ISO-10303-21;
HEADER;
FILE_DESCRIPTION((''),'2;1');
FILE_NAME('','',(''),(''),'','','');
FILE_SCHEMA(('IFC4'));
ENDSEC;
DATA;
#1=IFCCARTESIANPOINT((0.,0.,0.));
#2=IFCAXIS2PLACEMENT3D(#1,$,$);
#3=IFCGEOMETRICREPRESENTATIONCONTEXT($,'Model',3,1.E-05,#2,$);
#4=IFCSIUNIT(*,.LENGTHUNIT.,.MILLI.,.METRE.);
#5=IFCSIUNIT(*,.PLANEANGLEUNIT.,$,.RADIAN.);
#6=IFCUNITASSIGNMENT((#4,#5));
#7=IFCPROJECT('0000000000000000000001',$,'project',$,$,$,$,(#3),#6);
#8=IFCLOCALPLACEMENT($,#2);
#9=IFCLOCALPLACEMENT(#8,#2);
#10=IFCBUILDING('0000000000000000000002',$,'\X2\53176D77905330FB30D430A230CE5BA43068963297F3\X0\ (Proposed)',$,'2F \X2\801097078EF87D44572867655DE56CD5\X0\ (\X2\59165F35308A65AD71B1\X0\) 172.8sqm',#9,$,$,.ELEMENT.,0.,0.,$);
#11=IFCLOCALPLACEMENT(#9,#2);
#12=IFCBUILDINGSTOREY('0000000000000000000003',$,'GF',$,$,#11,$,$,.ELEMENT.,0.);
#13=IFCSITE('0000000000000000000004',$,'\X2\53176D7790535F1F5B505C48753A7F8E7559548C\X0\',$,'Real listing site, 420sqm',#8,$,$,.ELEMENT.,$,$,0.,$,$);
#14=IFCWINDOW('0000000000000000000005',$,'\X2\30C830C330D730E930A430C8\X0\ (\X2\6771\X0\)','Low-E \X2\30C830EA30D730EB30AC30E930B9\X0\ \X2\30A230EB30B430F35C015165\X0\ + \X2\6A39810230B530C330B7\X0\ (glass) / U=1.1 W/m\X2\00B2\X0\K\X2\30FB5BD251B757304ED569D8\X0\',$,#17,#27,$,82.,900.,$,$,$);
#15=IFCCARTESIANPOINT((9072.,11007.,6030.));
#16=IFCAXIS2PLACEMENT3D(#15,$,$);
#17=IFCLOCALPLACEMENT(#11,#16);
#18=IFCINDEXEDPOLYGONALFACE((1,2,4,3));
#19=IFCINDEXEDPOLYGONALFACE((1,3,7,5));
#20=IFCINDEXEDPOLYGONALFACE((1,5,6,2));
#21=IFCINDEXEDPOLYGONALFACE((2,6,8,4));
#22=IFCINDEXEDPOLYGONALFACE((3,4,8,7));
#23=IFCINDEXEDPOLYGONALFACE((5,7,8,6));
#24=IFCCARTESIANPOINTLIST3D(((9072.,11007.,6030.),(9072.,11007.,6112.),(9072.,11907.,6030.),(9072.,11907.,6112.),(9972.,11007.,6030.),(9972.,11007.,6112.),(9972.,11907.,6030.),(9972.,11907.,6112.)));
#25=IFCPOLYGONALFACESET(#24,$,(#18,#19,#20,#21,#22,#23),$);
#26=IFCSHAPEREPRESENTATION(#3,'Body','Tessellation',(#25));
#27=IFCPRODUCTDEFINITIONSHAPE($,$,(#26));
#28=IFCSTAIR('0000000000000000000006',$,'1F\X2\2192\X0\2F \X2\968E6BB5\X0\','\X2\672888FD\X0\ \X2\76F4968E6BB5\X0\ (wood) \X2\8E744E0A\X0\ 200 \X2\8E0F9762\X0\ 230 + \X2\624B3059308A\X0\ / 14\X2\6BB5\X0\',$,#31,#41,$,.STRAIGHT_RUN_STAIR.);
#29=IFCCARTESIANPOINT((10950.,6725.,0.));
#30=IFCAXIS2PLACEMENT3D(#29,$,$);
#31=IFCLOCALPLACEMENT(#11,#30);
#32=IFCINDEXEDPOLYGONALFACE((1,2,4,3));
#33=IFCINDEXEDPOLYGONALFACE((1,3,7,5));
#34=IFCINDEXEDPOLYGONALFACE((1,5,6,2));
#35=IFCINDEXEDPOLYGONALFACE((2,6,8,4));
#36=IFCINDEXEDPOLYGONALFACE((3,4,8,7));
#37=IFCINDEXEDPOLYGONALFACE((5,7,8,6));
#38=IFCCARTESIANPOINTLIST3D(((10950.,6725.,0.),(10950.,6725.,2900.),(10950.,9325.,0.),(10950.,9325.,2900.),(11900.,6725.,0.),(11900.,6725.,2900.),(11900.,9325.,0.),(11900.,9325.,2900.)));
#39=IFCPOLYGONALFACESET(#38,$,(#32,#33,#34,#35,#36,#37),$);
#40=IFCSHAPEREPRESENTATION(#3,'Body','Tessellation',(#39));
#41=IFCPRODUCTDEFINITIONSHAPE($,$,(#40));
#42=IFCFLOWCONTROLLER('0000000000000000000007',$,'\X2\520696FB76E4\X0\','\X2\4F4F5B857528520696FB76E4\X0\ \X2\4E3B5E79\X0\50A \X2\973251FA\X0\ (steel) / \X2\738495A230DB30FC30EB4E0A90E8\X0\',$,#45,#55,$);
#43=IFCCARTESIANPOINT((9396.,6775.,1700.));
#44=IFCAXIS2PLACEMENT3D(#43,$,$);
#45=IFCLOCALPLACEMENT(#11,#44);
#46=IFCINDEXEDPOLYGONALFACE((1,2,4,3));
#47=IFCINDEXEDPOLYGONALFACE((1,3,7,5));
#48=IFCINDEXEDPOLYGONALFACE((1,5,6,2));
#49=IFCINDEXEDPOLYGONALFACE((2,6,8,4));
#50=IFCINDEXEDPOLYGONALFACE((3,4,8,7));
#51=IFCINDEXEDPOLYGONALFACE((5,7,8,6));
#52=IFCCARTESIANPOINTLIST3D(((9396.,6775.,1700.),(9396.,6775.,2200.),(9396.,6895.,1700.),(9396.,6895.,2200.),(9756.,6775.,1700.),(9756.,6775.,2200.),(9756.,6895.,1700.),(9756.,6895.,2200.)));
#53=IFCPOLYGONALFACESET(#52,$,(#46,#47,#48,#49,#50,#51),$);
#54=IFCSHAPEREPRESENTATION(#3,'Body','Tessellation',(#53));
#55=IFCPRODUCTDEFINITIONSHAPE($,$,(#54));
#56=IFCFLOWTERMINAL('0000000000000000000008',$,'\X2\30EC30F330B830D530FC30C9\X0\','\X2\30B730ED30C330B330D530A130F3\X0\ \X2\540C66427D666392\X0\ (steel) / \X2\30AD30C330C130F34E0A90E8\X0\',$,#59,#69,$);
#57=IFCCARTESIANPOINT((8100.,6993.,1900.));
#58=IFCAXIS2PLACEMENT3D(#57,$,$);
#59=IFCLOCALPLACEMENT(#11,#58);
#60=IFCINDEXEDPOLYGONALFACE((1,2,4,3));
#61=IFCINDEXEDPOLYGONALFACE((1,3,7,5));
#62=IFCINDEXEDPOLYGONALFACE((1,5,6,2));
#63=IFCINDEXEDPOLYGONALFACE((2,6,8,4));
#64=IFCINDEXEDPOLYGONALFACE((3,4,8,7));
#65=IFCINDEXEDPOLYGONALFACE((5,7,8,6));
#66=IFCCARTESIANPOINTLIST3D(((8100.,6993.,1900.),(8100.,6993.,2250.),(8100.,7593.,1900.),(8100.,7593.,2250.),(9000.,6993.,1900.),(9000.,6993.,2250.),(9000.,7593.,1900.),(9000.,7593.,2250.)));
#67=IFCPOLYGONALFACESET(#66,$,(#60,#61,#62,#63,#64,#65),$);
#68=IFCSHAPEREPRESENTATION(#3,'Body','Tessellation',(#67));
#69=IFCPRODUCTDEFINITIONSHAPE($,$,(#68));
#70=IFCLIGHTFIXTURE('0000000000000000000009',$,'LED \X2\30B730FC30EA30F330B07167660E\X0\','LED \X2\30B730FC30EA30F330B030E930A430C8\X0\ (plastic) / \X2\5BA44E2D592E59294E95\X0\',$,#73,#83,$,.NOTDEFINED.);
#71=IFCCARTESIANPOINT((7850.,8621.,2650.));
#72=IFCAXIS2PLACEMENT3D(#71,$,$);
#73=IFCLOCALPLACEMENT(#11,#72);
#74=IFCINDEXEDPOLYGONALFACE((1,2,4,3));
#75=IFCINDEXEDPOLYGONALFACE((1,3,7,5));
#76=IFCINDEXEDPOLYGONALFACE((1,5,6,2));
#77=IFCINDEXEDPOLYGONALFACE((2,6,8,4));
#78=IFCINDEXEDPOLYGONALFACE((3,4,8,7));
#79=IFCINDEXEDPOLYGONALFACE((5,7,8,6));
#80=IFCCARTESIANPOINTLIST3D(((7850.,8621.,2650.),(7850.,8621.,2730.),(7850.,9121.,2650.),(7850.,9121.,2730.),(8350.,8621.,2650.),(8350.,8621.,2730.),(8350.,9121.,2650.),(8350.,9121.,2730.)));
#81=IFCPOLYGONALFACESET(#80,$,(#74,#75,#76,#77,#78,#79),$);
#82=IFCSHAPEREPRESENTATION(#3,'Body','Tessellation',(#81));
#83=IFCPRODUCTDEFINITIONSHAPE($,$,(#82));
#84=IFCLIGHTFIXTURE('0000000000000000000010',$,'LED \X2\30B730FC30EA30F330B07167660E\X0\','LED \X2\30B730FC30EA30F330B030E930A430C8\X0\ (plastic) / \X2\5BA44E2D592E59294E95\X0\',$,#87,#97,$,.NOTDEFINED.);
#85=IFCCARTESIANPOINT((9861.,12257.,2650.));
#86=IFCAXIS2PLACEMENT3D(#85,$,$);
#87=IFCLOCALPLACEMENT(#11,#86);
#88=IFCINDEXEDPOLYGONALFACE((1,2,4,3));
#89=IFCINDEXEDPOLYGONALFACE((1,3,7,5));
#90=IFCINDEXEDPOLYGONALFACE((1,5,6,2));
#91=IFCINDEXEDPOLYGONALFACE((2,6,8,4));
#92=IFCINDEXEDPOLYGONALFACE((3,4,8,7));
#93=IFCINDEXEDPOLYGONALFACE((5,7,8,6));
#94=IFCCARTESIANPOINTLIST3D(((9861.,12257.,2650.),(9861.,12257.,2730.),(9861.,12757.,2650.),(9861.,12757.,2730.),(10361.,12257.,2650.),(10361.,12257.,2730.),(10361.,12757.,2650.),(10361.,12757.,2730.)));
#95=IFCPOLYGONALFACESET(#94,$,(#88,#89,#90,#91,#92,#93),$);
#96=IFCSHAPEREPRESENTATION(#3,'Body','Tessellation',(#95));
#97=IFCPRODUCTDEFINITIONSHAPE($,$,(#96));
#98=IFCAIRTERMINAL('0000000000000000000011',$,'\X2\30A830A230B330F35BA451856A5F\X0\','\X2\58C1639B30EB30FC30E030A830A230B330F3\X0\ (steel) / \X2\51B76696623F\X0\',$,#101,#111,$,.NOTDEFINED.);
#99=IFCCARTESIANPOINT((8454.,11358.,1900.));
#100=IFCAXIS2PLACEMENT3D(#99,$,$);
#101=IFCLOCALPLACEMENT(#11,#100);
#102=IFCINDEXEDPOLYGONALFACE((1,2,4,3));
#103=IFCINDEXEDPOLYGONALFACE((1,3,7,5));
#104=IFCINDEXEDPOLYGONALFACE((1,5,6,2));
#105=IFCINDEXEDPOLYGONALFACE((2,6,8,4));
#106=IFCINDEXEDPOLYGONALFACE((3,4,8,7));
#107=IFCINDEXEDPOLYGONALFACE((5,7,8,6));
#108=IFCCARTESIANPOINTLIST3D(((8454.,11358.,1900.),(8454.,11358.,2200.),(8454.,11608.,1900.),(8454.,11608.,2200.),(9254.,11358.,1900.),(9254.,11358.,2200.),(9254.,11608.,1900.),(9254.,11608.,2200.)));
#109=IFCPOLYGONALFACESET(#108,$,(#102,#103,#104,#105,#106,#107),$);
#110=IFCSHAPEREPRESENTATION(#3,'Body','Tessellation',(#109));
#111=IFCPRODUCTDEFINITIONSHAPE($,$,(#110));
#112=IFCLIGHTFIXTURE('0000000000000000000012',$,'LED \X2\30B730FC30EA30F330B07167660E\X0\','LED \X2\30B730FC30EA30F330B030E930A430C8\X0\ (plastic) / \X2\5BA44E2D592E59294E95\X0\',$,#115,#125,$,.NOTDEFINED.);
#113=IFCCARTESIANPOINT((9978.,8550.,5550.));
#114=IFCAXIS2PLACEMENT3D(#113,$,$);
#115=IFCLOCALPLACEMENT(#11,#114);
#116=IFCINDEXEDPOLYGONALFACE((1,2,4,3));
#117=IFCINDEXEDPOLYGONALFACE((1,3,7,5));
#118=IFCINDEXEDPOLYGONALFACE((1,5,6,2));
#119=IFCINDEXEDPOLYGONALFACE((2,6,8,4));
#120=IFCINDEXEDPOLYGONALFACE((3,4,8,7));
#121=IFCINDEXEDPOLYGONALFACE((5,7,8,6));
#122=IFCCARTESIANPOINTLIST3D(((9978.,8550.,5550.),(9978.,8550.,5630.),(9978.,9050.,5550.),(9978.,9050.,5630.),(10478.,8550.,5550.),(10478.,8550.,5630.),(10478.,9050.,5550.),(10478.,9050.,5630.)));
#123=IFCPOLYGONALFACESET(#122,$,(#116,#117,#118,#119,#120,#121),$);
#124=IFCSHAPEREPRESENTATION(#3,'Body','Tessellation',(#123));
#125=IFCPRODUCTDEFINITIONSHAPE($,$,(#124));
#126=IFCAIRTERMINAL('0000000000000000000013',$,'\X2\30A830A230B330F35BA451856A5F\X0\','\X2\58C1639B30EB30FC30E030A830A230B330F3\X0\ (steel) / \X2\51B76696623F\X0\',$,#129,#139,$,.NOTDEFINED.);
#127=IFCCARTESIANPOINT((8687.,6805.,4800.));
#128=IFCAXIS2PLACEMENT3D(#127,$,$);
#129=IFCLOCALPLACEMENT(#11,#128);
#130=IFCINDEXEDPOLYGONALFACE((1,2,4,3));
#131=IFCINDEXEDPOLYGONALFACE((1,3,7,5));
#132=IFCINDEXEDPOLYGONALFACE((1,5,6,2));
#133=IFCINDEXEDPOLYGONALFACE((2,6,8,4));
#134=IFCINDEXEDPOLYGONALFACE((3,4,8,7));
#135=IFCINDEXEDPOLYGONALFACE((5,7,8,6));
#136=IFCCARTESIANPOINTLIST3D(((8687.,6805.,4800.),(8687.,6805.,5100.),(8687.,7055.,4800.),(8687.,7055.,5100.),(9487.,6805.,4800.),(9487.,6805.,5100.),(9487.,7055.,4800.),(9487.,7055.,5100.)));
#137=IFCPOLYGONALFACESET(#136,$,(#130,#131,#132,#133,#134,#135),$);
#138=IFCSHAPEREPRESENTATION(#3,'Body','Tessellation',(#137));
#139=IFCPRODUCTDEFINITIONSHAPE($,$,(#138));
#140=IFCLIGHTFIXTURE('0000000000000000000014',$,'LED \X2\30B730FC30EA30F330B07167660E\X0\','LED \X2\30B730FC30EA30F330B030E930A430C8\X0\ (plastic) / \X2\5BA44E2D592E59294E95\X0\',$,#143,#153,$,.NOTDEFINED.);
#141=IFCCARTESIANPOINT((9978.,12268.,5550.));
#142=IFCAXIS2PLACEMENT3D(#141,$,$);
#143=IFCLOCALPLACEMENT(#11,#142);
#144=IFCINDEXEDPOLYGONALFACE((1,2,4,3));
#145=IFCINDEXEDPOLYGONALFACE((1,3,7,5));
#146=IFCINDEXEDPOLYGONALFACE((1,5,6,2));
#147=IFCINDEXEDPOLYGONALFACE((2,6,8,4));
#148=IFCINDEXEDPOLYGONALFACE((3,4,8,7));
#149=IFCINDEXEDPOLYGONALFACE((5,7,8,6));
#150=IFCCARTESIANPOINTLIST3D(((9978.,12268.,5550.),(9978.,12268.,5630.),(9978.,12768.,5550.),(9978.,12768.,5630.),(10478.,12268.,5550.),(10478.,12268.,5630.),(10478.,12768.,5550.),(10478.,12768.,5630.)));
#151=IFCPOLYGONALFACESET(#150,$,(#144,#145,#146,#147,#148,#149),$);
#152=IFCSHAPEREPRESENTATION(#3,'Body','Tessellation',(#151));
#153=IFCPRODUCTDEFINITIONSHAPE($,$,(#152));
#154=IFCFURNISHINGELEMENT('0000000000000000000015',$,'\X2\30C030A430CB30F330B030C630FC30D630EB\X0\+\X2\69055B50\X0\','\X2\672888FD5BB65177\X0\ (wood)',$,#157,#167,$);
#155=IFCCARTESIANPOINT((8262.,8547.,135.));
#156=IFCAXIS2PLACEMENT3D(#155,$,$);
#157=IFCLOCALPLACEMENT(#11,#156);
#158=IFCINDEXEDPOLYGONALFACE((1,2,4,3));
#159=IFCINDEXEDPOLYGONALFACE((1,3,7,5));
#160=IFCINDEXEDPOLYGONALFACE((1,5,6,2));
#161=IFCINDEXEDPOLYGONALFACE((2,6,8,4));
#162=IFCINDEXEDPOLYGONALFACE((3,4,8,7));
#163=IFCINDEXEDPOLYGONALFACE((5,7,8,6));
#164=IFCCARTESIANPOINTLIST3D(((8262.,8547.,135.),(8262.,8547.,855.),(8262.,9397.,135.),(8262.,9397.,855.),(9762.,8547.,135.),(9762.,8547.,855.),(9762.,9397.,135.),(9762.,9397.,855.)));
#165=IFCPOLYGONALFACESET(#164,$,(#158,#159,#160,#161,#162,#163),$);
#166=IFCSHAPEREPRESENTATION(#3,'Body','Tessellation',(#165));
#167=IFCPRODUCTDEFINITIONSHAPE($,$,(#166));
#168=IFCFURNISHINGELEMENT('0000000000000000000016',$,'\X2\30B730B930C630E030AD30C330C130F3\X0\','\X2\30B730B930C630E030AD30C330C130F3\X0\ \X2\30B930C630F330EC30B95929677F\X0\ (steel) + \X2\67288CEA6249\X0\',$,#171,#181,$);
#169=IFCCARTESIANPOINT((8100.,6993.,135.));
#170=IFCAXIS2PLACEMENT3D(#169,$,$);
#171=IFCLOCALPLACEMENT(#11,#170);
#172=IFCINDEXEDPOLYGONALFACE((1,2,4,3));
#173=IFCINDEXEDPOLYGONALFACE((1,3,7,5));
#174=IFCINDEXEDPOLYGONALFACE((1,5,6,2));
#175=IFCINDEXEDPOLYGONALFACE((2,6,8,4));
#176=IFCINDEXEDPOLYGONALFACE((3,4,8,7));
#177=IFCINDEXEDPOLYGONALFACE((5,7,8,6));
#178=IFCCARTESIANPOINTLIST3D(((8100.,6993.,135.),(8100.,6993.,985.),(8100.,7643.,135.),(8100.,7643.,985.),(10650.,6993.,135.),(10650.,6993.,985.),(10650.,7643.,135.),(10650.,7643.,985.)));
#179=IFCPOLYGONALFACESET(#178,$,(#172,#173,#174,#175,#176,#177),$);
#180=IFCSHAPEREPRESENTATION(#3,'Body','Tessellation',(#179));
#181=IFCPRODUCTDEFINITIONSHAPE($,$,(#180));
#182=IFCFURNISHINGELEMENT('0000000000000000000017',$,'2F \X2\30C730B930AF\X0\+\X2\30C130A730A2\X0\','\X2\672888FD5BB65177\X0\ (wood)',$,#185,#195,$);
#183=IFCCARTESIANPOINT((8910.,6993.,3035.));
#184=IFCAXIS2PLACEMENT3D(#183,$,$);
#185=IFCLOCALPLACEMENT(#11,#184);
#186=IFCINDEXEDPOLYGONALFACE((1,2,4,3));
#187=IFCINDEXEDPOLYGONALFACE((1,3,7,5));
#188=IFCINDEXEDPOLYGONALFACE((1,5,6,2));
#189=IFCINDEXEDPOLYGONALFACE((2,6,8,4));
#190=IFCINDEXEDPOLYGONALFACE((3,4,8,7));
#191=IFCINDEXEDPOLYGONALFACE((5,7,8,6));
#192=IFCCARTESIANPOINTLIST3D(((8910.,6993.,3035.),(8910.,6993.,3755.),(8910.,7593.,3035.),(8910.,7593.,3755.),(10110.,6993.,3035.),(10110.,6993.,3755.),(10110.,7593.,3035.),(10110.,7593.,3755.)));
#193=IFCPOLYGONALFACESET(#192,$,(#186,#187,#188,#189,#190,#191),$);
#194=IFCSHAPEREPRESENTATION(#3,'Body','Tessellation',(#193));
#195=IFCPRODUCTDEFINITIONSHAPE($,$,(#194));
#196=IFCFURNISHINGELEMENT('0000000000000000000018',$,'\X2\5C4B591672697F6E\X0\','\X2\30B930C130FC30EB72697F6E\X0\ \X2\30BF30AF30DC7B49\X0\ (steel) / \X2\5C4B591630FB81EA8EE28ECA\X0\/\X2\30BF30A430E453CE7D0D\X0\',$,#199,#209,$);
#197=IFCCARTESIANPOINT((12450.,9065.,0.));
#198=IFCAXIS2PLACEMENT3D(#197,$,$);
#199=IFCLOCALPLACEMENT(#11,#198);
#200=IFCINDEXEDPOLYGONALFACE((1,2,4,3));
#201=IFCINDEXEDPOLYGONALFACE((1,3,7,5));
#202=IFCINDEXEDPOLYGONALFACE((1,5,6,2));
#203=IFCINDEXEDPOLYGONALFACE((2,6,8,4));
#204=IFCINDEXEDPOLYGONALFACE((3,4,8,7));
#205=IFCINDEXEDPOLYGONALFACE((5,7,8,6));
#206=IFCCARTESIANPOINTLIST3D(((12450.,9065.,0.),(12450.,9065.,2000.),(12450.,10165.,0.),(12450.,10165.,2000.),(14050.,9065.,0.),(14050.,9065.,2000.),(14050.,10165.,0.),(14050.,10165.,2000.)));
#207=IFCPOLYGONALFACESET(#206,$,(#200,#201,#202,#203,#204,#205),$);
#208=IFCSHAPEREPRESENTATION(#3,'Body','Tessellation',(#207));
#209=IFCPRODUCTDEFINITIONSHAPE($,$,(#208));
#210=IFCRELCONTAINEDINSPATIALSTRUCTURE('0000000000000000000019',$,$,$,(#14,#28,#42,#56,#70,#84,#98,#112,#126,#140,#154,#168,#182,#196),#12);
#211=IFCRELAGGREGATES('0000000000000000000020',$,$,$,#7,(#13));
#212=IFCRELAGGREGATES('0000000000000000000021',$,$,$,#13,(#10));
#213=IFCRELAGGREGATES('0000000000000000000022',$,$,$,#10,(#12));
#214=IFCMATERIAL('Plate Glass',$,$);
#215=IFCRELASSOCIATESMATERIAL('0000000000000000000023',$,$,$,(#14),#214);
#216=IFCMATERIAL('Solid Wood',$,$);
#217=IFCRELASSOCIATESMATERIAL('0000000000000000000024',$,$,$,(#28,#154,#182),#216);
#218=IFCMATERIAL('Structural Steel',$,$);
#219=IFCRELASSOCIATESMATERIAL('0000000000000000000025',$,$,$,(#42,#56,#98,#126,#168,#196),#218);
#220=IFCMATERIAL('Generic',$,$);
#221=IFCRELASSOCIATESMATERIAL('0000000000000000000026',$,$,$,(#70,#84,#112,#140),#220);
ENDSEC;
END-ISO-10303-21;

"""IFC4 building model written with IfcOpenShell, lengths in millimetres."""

from ifc_helpers import new_model, si_unit, frame, frame_2d, origin, place, context, project, spatial, rectangle, extrude, material, element, save


model = new_model("IFC4")

# Units and contexts
model_context = context("Model", 3, precision=1e-05, world=origin())
ifc_project = project(units=[si_unit("LENGTHUNIT", "METRE", prefix="MILLI"), si_unit("PLANEANGLEUNIT", "RADIAN")], contexts=[model_context])

# Site, building, storey
site_placement = place(None, origin())
site = spatial("IfcSite", under=ifc_project, at=site_placement, Name="北海道弟子屈町美留和", ObjectType="Real listing site, 420sqm", CompositionType="ELEMENT", RefElevation=0.0)
building_placement = place(site_placement, origin())
building = spatial("IfcBuilding", under=site, at=building_placement, Name="北海道・ピアノ室と防音 (Proposed)", ObjectType="2F 耐震軸組在来工法 (外張り断熱) 172.8sqm", CompositionType="ELEMENT", ElevationOfRefHeight=0.0, ElevationOfTerrain=0.0)
storey_placement = place(building_placement, origin())
storey = spatial("IfcBuildingStorey", under=building, at=storey_placement, Name="GF", CompositionType="ELEMENT", Elevation=0.0)

# Shared definitions
ifc_material_1 = material(Name="Solid Wood")

# Window
ifc_material_2 = material(Name="Plate Glass")
window_placement = place(storey_placement, frame((9072.0, 11007.0, 6030.0)))
element("IfcWindow", 1, at=window_placement, inside=storey, material=ifc_material_2, Name="トップライト (東)", Description="Low-E トリプルガラス アルゴン封入 + 樹脂サッシ (glass) / U=1.1 W/m²K・寒冷地仕様", OverallHeight=82.0, OverallWidth=900.0, context=model_context, shape_type="SweptSolid", body=[
    extrude(rectangle(XDim=900.0, YDim=900.0, at=frame_2d((450.0, 450.0))), frame((9072.0, 11007.0, 6030.0)), (0.0, 0.0, 1.0), 82.0),
])

# Stair
stair_placement = place(storey_placement, frame((10950.0, 6725.0, 0.0)))
element("IfcStair", 2, at=stair_placement, inside=storey, material=ifc_material_1, Name="1F→2F 階段", Description="木製 直階段 (wood) 蹴上 200 踏面 230 + 手すり / 14段", PredefinedType="STRAIGHT_RUN_STAIR", context=model_context, shape_type="SweptSolid", body=[
    extrude(rectangle(XDim=950.0, YDim=2600.0, at=frame_2d((475.0, 1300.0))), frame((10950.0, 6725.0, 0.0)), (0.0, 0.0, 1.0), 2900.0),
])

# Flow controller
ifc_material_3 = material(Name="Structural Steel")
flow_controller_placement = place(storey_placement, frame((9396.0, 6775.0, 1700.0)))
element("IfcFlowController", 3, at=flow_controller_placement, inside=storey, material=ifc_material_3, Name="分電盤", Description="住宅用分電盤 主幹50A 露出 (steel) / 玄関ホール上部", context=model_context, shape_type="SweptSolid", body=[
    extrude(rectangle(XDim=360.0, YDim=120.0, at=frame_2d((180.0, 60.0))), frame((9396.0, 6775.0, 1700.0)), (0.0, 0.0, 1.0), 500.0),
])

# Flow terminal
flow_terminal_placement = place(storey_placement, frame((8100.0, 6993.0, 1900.0)))
element("IfcFlowTerminal", 4, at=flow_terminal_placement, inside=storey, material=ifc_material_3, Name="レンジフード", Description="シロッコファン 同時給排 (steel) / キッチン上部", context=model_context, shape_type="SweptSolid", body=[
    extrude(rectangle(XDim=900.0, YDim=600.0, at=frame_2d((450.0, 300.0))), frame((8100.0, 6993.0, 1900.0)), (0.0, 0.0, 1.0), 350.0),
])

# Light fixtures
ifc_material_4 = material(Name="Generic")
light_fixture_1_placement = place(storey_placement, frame((7850.0, 8621.0, 2650.0)))
element("IfcLightFixture", 5, at=light_fixture_1_placement, inside=storey, material=ifc_material_4, Name="LED シーリング照明", Description="LED シーリングライト (plastic) / 室中央天井", PredefinedType="NOTDEFINED", context=model_context, shape_type="SweptSolid", body=[
    extrude(rectangle(XDim=500.0, YDim=500.0, at=frame_2d((250.0, 250.0))), frame((7850.0, 8621.0, 2650.0)), (0.0, 0.0, 1.0), 80.0),
])
light_fixture_2_placement = place(storey_placement, frame((9861.0, 12257.0, 2650.0)))
element("IfcLightFixture", 6, at=light_fixture_2_placement, inside=storey, material=ifc_material_4, Name="LED シーリング照明", Description="LED シーリングライト (plastic) / 室中央天井", PredefinedType="NOTDEFINED", context=model_context, shape_type="SweptSolid", body=[
    extrude(rectangle(XDim=500.0, YDim=500.0, at=frame_2d((250.0, 250.0))), frame((9861.0, 12257.0, 2650.0)), (0.0, 0.0, 1.0), 80.0),
])

# Air terminal
air_terminal_1_placement = place(storey_placement, frame((8454.0, 11358.0, 1900.0)))
element("IfcAirTerminal", 7, at=air_terminal_1_placement, inside=storey, material=ifc_material_3, Name="エアコン室内機", Description="壁掛ルームエアコン (steel) / 冷暖房", PredefinedType="NOTDEFINED", context=model_context, shape_type="SweptSolid", body=[
    extrude(rectangle(XDim=800.0, YDim=250.0, at=frame_2d((400.0, 125.0))), frame((8454.0, 11358.0, 1900.0)), (0.0, 0.0, 1.0), 300.0),
])

# Light fixture
light_fixture_3_placement = place(storey_placement, frame((9978.0, 8550.0, 5550.0)))
element("IfcLightFixture", 8, at=light_fixture_3_placement, inside=storey, material=ifc_material_4, Name="LED シーリング照明", Description="LED シーリングライト (plastic) / 室中央天井", PredefinedType="NOTDEFINED", context=model_context, shape_type="SweptSolid", body=[
    extrude(rectangle(XDim=500.0, YDim=500.0, at=frame_2d((250.0, 250.0))), frame((9978.0, 8550.0, 5550.0)), (0.0, 0.0, 1.0), 80.0),
])

# Air terminal
air_terminal_2_placement = place(storey_placement, frame((8687.0, 6805.0, 4800.0)))
element("IfcAirTerminal", 9, at=air_terminal_2_placement, inside=storey, material=ifc_material_3, Name="エアコン室内機", Description="壁掛ルームエアコン (steel) / 冷暖房", PredefinedType="NOTDEFINED", context=model_context, shape_type="SweptSolid", body=[
    extrude(rectangle(XDim=800.0, YDim=250.0, at=frame_2d((400.0, 125.0))), frame((8687.0, 6805.0, 4800.0)), (0.0, 0.0, 1.0), 300.0),
])

# Light fixture
light_fixture_4_placement = place(storey_placement, frame((9978.0, 12268.0, 5550.0)))
element("IfcLightFixture", 10, at=light_fixture_4_placement, inside=storey, material=ifc_material_4, Name="LED シーリング照明", Description="LED シーリングライト (plastic) / 室中央天井", PredefinedType="NOTDEFINED", context=model_context, shape_type="SweptSolid", body=[
    extrude(rectangle(XDim=500.0, YDim=500.0, at=frame_2d((250.0, 250.0))), frame((9978.0, 12268.0, 5550.0)), (0.0, 0.0, 1.0), 80.0),
])

# Furnishing elements
furnishing_1_placement = place(storey_placement, frame((8262.0, 8547.0, 135.0)))
element("IfcFurnishingElement", 11, at=furnishing_1_placement, inside=storey, material=ifc_material_1, Name="ダイニングテーブル+椅子", Description="木製家具 (wood)", context=model_context, shape_type="SweptSolid", body=[
    extrude(rectangle(XDim=1500.0, YDim=850.0, at=frame_2d((750.0, 425.0))), frame((8262.0, 8547.0, 135.0)), (0.0, 0.0, 1.0), 720.0),
])
furnishing_2_placement = place(storey_placement, frame((8100.0, 6993.0, 135.0)))
element("IfcFurnishingElement", 12, at=furnishing_2_placement, inside=storey, material=ifc_material_3, Name="システムキッチン", Description="システムキッチン ステンレス天板 (steel) + 木質扉", context=model_context, shape_type="SweptSolid", body=[
    extrude(rectangle(XDim=2550.0, YDim=650.0, at=frame_2d((1275.0, 325.0))), frame((8100.0, 6993.0, 135.0)), (0.0, 0.0, 1.0), 850.0),
])
furnishing_3_placement = place(storey_placement, frame((8910.0, 6993.0, 3035.0)))
element("IfcFurnishingElement", 13, at=furnishing_3_placement, inside=storey, material=ifc_material_1, Name="2F デスク+チェア", Description="木製家具 (wood)", context=model_context, shape_type="SweptSolid", body=[
    extrude(rectangle(XDim=1200.0, YDim=600.0, at=frame_2d((600.0, 300.0))), frame((8910.0, 6993.0, 3035.0)), (0.0, 0.0, 1.0), 720.0),
])
furnishing_4_placement = place(storey_placement, frame((12450.0, 9065.0, 0.0)))
element("IfcFurnishingElement", 14, at=furnishing_4_placement, inside=storey, material=ifc_material_3, Name="屋外物置", Description="スチール物置 タクボ等 (steel) / 屋外・自転車/タイヤ収納", context=model_context, shape_type="SweptSolid", body=[
    extrude(rectangle(XDim=1600.0, YDim=1100.0, at=frame_2d((800.0, 550.0))), frame((12450.0, 9065.0, 0.0)), (0.0, 0.0, 1.0), 2000.0),
])

save(model, "model.ifc")
